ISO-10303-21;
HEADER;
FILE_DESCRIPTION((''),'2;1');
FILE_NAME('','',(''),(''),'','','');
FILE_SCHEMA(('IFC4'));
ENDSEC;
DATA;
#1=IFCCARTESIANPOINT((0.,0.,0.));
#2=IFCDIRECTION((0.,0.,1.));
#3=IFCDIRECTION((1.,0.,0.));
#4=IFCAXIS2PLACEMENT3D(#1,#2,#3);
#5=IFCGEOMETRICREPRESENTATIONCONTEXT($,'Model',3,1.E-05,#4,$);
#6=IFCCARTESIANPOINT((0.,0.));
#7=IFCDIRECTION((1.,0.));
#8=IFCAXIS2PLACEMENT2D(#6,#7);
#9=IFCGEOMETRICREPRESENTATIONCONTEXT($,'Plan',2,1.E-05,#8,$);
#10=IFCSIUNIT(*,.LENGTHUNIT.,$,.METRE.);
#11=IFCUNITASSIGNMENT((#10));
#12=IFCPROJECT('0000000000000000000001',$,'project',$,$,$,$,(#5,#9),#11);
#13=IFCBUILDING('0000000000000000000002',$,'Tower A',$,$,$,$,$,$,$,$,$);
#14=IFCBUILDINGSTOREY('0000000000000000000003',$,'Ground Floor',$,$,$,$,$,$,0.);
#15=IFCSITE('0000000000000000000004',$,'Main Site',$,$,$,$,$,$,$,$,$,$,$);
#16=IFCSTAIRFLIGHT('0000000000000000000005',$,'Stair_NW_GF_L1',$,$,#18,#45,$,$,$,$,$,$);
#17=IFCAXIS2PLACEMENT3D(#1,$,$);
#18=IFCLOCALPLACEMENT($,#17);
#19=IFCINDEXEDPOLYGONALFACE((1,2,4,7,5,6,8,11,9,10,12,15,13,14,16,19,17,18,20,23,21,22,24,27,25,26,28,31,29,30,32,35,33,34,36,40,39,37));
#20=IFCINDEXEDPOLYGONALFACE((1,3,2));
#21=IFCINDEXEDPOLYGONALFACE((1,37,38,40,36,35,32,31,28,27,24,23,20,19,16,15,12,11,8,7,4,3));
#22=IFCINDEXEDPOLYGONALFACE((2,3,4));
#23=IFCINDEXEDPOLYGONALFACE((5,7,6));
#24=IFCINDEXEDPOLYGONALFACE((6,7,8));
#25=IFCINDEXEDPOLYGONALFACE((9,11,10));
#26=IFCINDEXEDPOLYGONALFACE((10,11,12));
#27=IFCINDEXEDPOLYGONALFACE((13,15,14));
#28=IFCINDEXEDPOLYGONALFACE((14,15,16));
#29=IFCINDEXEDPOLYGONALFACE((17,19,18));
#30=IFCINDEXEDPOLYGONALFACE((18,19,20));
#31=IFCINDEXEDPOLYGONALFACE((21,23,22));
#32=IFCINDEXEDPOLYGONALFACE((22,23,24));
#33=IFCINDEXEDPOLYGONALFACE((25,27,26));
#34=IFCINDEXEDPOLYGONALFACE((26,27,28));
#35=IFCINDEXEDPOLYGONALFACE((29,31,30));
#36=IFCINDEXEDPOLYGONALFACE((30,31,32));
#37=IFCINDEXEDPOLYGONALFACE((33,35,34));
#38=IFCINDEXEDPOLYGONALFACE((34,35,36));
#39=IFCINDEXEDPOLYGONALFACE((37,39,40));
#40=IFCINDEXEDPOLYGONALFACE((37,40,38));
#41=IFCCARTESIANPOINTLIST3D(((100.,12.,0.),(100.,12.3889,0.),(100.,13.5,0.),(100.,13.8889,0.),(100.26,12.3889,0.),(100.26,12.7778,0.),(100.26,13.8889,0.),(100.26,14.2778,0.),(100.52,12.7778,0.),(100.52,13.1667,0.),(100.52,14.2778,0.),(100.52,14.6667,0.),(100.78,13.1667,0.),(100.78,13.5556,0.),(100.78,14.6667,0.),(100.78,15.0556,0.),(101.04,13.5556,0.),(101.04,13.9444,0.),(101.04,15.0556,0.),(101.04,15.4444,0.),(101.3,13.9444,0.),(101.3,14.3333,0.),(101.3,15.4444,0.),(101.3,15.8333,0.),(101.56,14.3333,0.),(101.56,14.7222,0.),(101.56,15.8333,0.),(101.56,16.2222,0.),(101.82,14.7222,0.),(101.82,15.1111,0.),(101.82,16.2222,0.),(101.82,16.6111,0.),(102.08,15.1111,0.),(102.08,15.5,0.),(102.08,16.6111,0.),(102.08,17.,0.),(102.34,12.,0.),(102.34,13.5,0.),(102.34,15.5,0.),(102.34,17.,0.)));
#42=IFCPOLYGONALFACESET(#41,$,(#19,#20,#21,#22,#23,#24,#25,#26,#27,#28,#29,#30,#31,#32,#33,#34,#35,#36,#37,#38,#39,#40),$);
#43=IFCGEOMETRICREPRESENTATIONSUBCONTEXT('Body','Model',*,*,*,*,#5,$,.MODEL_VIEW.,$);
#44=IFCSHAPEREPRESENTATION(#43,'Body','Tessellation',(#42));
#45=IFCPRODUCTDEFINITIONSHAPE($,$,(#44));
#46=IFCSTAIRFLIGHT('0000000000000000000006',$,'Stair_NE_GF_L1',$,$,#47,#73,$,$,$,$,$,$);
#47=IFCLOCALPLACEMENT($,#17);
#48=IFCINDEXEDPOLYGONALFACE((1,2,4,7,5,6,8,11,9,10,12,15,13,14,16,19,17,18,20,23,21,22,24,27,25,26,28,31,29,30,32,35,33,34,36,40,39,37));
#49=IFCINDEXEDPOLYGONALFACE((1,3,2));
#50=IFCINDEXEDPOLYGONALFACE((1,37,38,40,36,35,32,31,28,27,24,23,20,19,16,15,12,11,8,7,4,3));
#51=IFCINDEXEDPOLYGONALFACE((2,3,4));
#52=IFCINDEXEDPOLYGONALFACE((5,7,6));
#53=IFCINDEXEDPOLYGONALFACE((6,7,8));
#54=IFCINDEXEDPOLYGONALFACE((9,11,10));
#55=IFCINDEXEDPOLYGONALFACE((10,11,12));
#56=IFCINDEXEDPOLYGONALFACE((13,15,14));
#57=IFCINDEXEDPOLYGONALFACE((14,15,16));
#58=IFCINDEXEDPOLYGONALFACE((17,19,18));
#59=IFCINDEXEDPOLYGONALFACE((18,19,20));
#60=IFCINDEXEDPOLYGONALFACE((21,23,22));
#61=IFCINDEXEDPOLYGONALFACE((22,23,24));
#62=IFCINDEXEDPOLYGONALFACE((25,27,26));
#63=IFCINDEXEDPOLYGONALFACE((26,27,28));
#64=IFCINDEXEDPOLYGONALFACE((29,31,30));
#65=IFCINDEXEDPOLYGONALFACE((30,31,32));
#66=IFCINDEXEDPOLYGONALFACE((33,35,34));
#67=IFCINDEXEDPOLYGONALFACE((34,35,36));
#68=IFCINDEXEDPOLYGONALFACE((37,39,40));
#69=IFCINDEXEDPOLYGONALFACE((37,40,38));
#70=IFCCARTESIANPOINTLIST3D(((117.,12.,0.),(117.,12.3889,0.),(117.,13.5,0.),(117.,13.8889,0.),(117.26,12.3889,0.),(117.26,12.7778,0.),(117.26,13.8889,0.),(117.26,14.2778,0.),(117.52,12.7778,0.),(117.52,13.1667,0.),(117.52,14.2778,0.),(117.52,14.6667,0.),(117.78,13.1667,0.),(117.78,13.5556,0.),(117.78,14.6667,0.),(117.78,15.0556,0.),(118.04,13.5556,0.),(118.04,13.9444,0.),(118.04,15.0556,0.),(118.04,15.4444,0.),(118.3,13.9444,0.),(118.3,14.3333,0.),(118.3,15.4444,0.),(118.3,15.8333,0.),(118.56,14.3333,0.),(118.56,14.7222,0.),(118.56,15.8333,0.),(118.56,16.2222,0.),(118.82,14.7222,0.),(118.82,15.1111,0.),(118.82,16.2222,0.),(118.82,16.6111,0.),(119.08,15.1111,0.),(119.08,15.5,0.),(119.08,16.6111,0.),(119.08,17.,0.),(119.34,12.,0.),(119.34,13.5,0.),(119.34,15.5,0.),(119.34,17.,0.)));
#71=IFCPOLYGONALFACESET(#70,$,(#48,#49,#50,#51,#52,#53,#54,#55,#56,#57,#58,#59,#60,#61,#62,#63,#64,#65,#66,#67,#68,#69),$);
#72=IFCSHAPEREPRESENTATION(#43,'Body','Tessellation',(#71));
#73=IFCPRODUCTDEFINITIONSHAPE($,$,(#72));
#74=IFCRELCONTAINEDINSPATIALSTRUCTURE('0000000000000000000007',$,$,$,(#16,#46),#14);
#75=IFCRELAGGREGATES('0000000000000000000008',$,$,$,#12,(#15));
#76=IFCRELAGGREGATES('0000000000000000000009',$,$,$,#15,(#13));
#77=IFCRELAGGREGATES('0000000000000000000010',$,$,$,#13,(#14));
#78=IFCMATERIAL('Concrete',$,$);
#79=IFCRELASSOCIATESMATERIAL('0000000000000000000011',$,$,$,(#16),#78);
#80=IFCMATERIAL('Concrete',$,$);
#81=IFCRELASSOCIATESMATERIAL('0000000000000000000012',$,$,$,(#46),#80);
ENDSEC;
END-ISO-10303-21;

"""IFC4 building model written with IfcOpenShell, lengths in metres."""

from ifc_helpers import new_model, si_unit, frame, origin_with_axes, origin_2d_with_axis, place, context, subcontext, project, spatial, line, indexed_curve, outline, extrude, material, element, save


model = new_model("IFC4")

# Units and contexts
model_context = context("Model", 3, precision=1e-05, world=origin_with_axes())
plan_context = context("Plan", 2, precision=1e-05, world=origin_2d_with_axis())
body_context = subcontext(model_context, "Body", "Model", "MODEL_VIEW")
ifc_project = project(units=[si_unit("LENGTHUNIT", "METRE")], contexts=[model_context, plan_context])

# Site, building, storey
site = spatial("IfcSite", under=ifc_project, Name="Main Site")
building = spatial("IfcBuilding", under=site, Name="Tower A")
storey = spatial("IfcBuildingStorey", under=building, Name="Ground Floor", Elevation=0.0)

# Stair flights
ifc_material_1 = material(Name="Concrete")
stair_flight_1_placement = place(None, frame((100.0, 12.0, 0.0), z_axis=(0.0, 0.0, 1.0), x_axis=(1.0, 0.0, 0.0)))
element("IfcStairFlight", 1, at=stair_flight_1_placement, inside=storey, material=ifc_material_1, Name="Stair_NW_GF_L1", context=body_context, shape_type="SweptSolid", body=[
    extrude(outline(indexed_curve([(0.0, 0.0), (0.0, 0.3889), (0.26, 0.3889), (0.26, 0.7778), (0.52, 0.7778), (0.52, 1.1667), (0.78, 1.1667), (0.78, 1.5556), (1.04, 1.5556), (1.04, 1.9444), (1.3, 1.9444), (1.3, 2.3333), (1.56, 2.3333), (1.56, 2.7222), (1.82, 2.7222), (1.82, 3.1111), (2.08, 3.1111), (2.08, 3.5), (2.34, 3.5), (2.34, 0.0)], segments=[line(1, 2, 3, 4, 5, 6, 7, 8, 9, 10, 11, 12, 13, 14, 15, 16, 17, 18, 19, 20, 1)])), origin_with_axes(), (0.0, 1.0, 0.0), 1.5),
])
ifc_material_2 = material(Name="Concrete")
stair_flight_2_placement = place(None, frame((117.0, 12.0, 0.0), z_axis=(0.0, 0.0, 1.0), x_axis=(1.0, 0.0, 0.0)))
element("IfcStairFlight", 2, at=stair_flight_2_placement, inside=storey, material=ifc_material_2, Name="Stair_NE_GF_L1", context=body_context, shape_type="SweptSolid", body=[
    extrude(outline(indexed_curve([(0.0, 0.0), (0.0, 0.3889), (0.26, 0.3889), (0.26, 0.7778), (0.52, 0.7778), (0.52, 1.1667), (0.78, 1.1667), (0.78, 1.5556), (1.04, 1.5556), (1.04, 1.9444), (1.3, 1.9444), (1.3, 2.3333), (1.56, 2.3333), (1.56, 2.7222), (1.82, 2.7222), (1.82, 3.1111), (2.08, 3.1111), (2.08, 3.5), (2.34, 3.5), (2.34, 0.0)], segments=[line(1, 2, 3, 4, 5, 6, 7, 8, 9, 10, 11, 12, 13, 14, 15, 16, 17, 18, 19, 20, 1)])), origin_with_axes(), (0.0, 1.0, 0.0), 1.5),
])

save(model, "model.ifc")
